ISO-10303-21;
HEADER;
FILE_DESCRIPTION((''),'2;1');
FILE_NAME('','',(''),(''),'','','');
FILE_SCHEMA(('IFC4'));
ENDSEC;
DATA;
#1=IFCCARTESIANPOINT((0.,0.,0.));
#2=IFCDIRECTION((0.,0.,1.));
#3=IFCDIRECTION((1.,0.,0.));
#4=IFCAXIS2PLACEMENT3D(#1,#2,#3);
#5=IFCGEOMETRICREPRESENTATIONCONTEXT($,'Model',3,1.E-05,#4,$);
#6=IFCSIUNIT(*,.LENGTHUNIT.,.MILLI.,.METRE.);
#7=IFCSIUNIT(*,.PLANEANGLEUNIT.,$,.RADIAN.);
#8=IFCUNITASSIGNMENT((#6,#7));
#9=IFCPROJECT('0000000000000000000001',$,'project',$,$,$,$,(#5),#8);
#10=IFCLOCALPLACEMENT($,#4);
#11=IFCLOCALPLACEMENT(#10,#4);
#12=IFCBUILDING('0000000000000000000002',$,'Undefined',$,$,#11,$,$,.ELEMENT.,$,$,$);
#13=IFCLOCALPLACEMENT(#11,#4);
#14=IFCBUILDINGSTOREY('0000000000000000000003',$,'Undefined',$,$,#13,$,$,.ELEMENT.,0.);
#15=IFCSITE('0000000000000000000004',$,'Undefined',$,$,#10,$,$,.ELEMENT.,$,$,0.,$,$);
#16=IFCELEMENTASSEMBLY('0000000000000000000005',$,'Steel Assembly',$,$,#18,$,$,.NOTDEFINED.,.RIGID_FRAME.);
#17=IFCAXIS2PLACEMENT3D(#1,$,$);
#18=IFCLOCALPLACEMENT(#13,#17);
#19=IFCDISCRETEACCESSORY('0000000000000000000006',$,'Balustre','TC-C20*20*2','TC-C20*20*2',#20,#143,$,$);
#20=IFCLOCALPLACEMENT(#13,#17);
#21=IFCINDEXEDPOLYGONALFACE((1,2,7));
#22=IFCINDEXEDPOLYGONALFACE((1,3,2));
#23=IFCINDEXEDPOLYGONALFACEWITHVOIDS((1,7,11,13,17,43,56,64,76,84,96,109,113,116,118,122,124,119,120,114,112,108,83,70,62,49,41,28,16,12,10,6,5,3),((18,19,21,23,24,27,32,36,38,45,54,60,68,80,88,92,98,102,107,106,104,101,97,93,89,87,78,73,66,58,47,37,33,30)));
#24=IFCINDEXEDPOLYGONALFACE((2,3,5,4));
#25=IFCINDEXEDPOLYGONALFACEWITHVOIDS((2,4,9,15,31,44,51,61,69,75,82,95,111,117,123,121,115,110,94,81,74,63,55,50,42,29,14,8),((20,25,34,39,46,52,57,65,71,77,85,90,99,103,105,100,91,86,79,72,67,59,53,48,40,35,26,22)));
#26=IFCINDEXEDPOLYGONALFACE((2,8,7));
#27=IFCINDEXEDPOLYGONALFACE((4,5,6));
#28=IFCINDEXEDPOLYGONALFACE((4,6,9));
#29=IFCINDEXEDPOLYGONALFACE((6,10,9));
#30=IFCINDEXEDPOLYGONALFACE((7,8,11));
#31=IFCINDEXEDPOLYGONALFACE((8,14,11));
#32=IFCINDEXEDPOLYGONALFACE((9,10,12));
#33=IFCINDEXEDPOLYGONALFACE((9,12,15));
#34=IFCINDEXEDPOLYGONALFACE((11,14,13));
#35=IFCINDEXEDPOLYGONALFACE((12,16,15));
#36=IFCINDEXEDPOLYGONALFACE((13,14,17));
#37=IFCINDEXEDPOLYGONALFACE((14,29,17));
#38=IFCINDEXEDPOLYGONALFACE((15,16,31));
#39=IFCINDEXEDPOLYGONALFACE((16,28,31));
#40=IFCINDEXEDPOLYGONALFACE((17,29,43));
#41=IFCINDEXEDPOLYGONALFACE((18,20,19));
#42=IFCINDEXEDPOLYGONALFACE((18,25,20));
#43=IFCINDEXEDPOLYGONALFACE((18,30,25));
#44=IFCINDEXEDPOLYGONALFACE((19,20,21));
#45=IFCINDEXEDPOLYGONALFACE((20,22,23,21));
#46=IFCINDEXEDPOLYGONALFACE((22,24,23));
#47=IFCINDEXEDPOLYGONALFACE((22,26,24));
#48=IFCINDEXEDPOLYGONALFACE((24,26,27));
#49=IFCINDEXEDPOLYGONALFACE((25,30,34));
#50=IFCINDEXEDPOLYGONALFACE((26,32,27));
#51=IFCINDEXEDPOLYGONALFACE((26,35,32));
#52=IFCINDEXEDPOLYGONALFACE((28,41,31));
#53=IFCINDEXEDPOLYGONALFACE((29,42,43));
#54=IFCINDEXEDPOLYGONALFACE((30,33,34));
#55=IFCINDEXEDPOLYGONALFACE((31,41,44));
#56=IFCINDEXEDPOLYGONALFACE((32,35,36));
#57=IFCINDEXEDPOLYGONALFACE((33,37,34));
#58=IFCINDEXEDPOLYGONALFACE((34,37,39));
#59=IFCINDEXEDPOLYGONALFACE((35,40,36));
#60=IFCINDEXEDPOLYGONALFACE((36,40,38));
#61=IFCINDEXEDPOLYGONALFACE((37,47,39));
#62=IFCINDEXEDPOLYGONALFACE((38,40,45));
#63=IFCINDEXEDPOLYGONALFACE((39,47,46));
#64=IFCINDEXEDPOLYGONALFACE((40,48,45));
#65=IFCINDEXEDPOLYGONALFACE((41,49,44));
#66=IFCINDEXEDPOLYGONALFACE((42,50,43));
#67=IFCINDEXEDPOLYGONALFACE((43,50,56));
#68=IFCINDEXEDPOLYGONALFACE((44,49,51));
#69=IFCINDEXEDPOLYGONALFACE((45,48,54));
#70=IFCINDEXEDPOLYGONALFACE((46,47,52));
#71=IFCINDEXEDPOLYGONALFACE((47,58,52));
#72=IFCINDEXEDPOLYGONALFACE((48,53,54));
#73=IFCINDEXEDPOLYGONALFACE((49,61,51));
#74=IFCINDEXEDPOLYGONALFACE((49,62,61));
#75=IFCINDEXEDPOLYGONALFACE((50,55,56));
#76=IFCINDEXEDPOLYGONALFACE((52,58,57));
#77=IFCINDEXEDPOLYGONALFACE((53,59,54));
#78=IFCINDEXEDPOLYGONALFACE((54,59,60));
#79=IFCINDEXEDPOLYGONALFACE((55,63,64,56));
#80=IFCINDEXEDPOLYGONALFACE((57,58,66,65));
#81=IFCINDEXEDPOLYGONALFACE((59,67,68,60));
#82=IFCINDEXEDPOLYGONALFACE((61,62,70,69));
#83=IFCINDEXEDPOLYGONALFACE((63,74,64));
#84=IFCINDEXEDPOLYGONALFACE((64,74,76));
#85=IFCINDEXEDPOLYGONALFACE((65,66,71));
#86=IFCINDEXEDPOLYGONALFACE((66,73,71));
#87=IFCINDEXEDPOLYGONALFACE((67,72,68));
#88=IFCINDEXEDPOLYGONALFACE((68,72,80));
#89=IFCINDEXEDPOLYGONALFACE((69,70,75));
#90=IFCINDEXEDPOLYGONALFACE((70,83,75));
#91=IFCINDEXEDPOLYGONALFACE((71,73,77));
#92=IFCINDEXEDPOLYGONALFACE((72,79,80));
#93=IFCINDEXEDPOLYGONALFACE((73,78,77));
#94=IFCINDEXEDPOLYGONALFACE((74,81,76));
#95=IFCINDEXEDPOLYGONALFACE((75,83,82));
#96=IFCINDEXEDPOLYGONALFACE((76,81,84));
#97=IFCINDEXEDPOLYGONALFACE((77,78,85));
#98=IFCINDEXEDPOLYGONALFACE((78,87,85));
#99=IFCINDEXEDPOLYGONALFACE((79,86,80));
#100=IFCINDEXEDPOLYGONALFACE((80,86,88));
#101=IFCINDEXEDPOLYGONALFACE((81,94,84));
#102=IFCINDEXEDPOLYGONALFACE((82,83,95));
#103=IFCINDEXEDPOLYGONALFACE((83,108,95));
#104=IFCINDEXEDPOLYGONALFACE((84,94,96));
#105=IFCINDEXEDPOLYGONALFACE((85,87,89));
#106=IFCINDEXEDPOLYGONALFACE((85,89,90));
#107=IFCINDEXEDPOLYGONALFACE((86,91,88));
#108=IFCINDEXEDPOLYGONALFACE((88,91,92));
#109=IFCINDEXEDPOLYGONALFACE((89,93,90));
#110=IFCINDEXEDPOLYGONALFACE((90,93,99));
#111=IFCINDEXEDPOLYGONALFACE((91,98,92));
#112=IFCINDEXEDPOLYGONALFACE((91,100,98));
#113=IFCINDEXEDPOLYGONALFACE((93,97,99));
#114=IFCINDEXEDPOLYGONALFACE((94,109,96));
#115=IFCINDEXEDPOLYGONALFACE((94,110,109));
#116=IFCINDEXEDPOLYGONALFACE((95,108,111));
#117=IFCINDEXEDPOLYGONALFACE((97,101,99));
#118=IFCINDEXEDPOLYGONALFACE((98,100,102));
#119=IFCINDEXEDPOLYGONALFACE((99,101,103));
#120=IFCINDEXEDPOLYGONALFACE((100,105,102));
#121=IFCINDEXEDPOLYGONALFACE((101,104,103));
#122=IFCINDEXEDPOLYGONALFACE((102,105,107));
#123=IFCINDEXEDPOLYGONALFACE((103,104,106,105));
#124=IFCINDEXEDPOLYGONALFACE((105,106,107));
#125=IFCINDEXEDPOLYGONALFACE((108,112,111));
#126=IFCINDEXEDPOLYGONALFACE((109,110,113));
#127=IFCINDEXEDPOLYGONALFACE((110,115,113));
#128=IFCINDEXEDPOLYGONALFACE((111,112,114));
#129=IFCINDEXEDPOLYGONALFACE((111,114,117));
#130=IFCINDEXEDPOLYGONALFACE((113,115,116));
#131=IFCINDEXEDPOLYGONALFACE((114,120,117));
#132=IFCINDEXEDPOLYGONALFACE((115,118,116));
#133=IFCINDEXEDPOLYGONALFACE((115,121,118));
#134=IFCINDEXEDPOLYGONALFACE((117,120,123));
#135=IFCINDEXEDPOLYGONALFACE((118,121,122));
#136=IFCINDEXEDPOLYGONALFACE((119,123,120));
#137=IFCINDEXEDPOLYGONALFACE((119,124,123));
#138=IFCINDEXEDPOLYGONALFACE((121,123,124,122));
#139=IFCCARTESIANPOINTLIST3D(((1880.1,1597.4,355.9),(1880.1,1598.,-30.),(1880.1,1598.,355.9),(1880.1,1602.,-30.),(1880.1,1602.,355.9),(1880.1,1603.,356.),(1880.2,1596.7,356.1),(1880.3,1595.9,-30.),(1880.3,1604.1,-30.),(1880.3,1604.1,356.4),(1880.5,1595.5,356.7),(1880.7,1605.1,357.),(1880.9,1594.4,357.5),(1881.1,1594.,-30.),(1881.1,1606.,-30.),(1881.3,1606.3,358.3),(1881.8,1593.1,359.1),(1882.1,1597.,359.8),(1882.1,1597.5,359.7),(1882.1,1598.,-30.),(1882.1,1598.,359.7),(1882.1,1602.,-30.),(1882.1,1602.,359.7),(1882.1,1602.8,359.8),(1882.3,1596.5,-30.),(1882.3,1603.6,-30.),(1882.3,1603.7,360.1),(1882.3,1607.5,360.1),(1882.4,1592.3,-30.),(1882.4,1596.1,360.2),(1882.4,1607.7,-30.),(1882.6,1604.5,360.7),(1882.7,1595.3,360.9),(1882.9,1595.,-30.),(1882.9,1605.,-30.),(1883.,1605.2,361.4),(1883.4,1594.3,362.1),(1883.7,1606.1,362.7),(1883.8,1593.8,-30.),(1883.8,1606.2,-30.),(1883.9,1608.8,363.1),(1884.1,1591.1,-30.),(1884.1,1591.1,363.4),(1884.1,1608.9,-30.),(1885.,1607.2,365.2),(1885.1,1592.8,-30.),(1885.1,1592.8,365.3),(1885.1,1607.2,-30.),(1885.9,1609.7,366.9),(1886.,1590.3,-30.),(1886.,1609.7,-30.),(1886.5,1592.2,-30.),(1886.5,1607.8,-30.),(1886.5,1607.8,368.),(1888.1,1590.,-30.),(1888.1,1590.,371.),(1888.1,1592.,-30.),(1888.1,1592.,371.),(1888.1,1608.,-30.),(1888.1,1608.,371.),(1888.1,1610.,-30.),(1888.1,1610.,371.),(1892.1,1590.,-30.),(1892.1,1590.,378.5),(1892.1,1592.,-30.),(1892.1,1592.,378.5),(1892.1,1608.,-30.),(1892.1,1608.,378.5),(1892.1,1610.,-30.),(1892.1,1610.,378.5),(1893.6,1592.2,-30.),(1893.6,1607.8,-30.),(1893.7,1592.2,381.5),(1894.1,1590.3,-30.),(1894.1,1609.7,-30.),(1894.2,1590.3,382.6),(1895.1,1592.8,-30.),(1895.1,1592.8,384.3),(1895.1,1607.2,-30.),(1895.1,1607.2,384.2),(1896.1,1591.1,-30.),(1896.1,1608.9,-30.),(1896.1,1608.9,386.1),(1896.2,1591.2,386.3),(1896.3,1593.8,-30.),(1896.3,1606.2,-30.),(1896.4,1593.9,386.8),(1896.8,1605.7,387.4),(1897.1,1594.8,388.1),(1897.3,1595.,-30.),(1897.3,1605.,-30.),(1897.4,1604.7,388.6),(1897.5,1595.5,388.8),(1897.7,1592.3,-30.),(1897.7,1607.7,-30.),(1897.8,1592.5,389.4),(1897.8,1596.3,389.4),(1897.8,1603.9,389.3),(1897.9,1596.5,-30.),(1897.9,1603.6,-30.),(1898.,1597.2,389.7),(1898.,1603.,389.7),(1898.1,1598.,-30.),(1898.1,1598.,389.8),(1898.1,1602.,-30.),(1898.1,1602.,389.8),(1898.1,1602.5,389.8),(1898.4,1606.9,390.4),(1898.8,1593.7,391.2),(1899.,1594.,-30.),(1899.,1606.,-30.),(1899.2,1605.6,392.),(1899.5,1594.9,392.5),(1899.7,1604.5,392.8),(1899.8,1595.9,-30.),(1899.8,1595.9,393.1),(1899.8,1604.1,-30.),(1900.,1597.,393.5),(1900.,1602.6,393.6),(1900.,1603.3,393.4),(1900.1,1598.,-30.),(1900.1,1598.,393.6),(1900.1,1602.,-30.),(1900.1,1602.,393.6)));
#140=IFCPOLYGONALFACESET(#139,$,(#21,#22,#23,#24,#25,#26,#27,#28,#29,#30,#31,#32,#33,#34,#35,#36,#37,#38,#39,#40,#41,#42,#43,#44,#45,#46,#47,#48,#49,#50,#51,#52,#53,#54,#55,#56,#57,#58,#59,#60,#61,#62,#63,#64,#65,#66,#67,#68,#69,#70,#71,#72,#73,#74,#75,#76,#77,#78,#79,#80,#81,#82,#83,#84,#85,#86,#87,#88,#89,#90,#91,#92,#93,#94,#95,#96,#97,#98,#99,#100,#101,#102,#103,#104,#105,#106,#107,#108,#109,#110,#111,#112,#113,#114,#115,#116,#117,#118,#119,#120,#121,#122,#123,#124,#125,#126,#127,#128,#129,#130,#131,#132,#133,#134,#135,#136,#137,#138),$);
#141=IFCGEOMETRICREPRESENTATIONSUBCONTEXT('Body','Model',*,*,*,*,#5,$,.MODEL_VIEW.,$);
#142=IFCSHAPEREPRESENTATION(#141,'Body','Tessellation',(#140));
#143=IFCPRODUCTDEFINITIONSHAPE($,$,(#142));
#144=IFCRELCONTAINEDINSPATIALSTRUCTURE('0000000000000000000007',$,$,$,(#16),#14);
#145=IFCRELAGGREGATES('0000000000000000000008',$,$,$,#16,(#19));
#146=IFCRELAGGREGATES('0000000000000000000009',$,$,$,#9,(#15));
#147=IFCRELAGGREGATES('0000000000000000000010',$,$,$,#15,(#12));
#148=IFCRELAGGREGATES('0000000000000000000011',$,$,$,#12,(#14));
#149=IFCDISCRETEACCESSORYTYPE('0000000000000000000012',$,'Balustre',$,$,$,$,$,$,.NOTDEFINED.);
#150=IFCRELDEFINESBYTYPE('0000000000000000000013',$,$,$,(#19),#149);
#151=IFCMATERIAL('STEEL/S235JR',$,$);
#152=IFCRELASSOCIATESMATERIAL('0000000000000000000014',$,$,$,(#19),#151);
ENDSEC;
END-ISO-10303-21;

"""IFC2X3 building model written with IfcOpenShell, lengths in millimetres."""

from ifc_helpers import new_model, si_unit, frame, origin_with_axes, origin_2d_with_axis, place, context, subcontext, project, spatial, hollow_rectangle, extrude, clip, halfspace, material, type_object, element, aggregate, save


model = new_model("IFC2X3")

# Units and contexts
model_context = context("Model", 3, precision=1e-05, world=origin_with_axes())
body_context = subcontext(model_context, "Body", "Model", "MODEL_VIEW")
ifc_project = project(units=[si_unit("LENGTHUNIT", "METRE", prefix="MILLI"), si_unit("PLANEANGLEUNIT", "RADIAN")], contexts=[model_context])

# Site, building, storey
site_placement = place(None, origin_with_axes())
site = spatial("IfcSite", under=ifc_project, at=site_placement, Name="Undefined", CompositionType="ELEMENT", RefElevation=0.0)
building_placement = place(site_placement, origin_with_axes())
building = spatial("IfcBuilding", under=site, at=building_placement, Name="Undefined", CompositionType="ELEMENT")
storey_placement = place(building_placement, origin_with_axes())
storey = spatial("IfcBuildingStorey", under=building, at=storey_placement, Name="Undefined", CompositionType="ELEMENT", Elevation=0.0)

# Element assembly
assembly_1_placement = place(storey_placement, origin_with_axes())
assembly_1 = element("IfcElementAssembly", 1, at=assembly_1_placement, inside=storey, Name="Steel Assembly", AssemblyPlace="NOTDEFINED", PredefinedType="RIGID_FRAME")
ifc_material = material(Name="STEEL/S235JR")

# Discrete accessory
discrete_accessory_type_1 = type_object("IfcDiscreteAccessoryType", Name="Balustre")
discrete_accessory_1_placement = place(assembly_1_placement, frame((1890.1, 1600.0, -30.0), z_axis=(0.0, 0.0, 1.0), x_axis=(1.0, 0.0, 0.0)))
discrete_accessory_1 = element("IfcDiscreteAccessory", 2, at=discrete_accessory_1_placement, type_object=discrete_accessory_type_1, material=ifc_material, Name="Balustre", Description="TC-C20*20*2", ObjectType="TC-C20*20*2", context=body_context, shape_type="Clipping", body=[
    clip(extrude(hollow_rectangle(XDim=20.0, YDim=20.0, WallThickness=2.0, InnerFilletRadius=6.0, OuterFilletRadius=8.0, at=origin_2d_with_axis()), frame((0.0, 0.0, 423.8), z_axis=(0.0, 0.0, -1.0), x_axis=(-1.0, 0.0, 0.0)), (0.0, 0.0, 1.0), 423.8), halfspace(frame((13.3, 0.0, 429.9), z_axis=(0.883506, 0.000005, -0.46842), x_axis=(-0.000005, 1.0, 0.0)), True)),
])
aggregate(assembly_1, [discrete_accessory_1])

save(model, "model.ifc")
